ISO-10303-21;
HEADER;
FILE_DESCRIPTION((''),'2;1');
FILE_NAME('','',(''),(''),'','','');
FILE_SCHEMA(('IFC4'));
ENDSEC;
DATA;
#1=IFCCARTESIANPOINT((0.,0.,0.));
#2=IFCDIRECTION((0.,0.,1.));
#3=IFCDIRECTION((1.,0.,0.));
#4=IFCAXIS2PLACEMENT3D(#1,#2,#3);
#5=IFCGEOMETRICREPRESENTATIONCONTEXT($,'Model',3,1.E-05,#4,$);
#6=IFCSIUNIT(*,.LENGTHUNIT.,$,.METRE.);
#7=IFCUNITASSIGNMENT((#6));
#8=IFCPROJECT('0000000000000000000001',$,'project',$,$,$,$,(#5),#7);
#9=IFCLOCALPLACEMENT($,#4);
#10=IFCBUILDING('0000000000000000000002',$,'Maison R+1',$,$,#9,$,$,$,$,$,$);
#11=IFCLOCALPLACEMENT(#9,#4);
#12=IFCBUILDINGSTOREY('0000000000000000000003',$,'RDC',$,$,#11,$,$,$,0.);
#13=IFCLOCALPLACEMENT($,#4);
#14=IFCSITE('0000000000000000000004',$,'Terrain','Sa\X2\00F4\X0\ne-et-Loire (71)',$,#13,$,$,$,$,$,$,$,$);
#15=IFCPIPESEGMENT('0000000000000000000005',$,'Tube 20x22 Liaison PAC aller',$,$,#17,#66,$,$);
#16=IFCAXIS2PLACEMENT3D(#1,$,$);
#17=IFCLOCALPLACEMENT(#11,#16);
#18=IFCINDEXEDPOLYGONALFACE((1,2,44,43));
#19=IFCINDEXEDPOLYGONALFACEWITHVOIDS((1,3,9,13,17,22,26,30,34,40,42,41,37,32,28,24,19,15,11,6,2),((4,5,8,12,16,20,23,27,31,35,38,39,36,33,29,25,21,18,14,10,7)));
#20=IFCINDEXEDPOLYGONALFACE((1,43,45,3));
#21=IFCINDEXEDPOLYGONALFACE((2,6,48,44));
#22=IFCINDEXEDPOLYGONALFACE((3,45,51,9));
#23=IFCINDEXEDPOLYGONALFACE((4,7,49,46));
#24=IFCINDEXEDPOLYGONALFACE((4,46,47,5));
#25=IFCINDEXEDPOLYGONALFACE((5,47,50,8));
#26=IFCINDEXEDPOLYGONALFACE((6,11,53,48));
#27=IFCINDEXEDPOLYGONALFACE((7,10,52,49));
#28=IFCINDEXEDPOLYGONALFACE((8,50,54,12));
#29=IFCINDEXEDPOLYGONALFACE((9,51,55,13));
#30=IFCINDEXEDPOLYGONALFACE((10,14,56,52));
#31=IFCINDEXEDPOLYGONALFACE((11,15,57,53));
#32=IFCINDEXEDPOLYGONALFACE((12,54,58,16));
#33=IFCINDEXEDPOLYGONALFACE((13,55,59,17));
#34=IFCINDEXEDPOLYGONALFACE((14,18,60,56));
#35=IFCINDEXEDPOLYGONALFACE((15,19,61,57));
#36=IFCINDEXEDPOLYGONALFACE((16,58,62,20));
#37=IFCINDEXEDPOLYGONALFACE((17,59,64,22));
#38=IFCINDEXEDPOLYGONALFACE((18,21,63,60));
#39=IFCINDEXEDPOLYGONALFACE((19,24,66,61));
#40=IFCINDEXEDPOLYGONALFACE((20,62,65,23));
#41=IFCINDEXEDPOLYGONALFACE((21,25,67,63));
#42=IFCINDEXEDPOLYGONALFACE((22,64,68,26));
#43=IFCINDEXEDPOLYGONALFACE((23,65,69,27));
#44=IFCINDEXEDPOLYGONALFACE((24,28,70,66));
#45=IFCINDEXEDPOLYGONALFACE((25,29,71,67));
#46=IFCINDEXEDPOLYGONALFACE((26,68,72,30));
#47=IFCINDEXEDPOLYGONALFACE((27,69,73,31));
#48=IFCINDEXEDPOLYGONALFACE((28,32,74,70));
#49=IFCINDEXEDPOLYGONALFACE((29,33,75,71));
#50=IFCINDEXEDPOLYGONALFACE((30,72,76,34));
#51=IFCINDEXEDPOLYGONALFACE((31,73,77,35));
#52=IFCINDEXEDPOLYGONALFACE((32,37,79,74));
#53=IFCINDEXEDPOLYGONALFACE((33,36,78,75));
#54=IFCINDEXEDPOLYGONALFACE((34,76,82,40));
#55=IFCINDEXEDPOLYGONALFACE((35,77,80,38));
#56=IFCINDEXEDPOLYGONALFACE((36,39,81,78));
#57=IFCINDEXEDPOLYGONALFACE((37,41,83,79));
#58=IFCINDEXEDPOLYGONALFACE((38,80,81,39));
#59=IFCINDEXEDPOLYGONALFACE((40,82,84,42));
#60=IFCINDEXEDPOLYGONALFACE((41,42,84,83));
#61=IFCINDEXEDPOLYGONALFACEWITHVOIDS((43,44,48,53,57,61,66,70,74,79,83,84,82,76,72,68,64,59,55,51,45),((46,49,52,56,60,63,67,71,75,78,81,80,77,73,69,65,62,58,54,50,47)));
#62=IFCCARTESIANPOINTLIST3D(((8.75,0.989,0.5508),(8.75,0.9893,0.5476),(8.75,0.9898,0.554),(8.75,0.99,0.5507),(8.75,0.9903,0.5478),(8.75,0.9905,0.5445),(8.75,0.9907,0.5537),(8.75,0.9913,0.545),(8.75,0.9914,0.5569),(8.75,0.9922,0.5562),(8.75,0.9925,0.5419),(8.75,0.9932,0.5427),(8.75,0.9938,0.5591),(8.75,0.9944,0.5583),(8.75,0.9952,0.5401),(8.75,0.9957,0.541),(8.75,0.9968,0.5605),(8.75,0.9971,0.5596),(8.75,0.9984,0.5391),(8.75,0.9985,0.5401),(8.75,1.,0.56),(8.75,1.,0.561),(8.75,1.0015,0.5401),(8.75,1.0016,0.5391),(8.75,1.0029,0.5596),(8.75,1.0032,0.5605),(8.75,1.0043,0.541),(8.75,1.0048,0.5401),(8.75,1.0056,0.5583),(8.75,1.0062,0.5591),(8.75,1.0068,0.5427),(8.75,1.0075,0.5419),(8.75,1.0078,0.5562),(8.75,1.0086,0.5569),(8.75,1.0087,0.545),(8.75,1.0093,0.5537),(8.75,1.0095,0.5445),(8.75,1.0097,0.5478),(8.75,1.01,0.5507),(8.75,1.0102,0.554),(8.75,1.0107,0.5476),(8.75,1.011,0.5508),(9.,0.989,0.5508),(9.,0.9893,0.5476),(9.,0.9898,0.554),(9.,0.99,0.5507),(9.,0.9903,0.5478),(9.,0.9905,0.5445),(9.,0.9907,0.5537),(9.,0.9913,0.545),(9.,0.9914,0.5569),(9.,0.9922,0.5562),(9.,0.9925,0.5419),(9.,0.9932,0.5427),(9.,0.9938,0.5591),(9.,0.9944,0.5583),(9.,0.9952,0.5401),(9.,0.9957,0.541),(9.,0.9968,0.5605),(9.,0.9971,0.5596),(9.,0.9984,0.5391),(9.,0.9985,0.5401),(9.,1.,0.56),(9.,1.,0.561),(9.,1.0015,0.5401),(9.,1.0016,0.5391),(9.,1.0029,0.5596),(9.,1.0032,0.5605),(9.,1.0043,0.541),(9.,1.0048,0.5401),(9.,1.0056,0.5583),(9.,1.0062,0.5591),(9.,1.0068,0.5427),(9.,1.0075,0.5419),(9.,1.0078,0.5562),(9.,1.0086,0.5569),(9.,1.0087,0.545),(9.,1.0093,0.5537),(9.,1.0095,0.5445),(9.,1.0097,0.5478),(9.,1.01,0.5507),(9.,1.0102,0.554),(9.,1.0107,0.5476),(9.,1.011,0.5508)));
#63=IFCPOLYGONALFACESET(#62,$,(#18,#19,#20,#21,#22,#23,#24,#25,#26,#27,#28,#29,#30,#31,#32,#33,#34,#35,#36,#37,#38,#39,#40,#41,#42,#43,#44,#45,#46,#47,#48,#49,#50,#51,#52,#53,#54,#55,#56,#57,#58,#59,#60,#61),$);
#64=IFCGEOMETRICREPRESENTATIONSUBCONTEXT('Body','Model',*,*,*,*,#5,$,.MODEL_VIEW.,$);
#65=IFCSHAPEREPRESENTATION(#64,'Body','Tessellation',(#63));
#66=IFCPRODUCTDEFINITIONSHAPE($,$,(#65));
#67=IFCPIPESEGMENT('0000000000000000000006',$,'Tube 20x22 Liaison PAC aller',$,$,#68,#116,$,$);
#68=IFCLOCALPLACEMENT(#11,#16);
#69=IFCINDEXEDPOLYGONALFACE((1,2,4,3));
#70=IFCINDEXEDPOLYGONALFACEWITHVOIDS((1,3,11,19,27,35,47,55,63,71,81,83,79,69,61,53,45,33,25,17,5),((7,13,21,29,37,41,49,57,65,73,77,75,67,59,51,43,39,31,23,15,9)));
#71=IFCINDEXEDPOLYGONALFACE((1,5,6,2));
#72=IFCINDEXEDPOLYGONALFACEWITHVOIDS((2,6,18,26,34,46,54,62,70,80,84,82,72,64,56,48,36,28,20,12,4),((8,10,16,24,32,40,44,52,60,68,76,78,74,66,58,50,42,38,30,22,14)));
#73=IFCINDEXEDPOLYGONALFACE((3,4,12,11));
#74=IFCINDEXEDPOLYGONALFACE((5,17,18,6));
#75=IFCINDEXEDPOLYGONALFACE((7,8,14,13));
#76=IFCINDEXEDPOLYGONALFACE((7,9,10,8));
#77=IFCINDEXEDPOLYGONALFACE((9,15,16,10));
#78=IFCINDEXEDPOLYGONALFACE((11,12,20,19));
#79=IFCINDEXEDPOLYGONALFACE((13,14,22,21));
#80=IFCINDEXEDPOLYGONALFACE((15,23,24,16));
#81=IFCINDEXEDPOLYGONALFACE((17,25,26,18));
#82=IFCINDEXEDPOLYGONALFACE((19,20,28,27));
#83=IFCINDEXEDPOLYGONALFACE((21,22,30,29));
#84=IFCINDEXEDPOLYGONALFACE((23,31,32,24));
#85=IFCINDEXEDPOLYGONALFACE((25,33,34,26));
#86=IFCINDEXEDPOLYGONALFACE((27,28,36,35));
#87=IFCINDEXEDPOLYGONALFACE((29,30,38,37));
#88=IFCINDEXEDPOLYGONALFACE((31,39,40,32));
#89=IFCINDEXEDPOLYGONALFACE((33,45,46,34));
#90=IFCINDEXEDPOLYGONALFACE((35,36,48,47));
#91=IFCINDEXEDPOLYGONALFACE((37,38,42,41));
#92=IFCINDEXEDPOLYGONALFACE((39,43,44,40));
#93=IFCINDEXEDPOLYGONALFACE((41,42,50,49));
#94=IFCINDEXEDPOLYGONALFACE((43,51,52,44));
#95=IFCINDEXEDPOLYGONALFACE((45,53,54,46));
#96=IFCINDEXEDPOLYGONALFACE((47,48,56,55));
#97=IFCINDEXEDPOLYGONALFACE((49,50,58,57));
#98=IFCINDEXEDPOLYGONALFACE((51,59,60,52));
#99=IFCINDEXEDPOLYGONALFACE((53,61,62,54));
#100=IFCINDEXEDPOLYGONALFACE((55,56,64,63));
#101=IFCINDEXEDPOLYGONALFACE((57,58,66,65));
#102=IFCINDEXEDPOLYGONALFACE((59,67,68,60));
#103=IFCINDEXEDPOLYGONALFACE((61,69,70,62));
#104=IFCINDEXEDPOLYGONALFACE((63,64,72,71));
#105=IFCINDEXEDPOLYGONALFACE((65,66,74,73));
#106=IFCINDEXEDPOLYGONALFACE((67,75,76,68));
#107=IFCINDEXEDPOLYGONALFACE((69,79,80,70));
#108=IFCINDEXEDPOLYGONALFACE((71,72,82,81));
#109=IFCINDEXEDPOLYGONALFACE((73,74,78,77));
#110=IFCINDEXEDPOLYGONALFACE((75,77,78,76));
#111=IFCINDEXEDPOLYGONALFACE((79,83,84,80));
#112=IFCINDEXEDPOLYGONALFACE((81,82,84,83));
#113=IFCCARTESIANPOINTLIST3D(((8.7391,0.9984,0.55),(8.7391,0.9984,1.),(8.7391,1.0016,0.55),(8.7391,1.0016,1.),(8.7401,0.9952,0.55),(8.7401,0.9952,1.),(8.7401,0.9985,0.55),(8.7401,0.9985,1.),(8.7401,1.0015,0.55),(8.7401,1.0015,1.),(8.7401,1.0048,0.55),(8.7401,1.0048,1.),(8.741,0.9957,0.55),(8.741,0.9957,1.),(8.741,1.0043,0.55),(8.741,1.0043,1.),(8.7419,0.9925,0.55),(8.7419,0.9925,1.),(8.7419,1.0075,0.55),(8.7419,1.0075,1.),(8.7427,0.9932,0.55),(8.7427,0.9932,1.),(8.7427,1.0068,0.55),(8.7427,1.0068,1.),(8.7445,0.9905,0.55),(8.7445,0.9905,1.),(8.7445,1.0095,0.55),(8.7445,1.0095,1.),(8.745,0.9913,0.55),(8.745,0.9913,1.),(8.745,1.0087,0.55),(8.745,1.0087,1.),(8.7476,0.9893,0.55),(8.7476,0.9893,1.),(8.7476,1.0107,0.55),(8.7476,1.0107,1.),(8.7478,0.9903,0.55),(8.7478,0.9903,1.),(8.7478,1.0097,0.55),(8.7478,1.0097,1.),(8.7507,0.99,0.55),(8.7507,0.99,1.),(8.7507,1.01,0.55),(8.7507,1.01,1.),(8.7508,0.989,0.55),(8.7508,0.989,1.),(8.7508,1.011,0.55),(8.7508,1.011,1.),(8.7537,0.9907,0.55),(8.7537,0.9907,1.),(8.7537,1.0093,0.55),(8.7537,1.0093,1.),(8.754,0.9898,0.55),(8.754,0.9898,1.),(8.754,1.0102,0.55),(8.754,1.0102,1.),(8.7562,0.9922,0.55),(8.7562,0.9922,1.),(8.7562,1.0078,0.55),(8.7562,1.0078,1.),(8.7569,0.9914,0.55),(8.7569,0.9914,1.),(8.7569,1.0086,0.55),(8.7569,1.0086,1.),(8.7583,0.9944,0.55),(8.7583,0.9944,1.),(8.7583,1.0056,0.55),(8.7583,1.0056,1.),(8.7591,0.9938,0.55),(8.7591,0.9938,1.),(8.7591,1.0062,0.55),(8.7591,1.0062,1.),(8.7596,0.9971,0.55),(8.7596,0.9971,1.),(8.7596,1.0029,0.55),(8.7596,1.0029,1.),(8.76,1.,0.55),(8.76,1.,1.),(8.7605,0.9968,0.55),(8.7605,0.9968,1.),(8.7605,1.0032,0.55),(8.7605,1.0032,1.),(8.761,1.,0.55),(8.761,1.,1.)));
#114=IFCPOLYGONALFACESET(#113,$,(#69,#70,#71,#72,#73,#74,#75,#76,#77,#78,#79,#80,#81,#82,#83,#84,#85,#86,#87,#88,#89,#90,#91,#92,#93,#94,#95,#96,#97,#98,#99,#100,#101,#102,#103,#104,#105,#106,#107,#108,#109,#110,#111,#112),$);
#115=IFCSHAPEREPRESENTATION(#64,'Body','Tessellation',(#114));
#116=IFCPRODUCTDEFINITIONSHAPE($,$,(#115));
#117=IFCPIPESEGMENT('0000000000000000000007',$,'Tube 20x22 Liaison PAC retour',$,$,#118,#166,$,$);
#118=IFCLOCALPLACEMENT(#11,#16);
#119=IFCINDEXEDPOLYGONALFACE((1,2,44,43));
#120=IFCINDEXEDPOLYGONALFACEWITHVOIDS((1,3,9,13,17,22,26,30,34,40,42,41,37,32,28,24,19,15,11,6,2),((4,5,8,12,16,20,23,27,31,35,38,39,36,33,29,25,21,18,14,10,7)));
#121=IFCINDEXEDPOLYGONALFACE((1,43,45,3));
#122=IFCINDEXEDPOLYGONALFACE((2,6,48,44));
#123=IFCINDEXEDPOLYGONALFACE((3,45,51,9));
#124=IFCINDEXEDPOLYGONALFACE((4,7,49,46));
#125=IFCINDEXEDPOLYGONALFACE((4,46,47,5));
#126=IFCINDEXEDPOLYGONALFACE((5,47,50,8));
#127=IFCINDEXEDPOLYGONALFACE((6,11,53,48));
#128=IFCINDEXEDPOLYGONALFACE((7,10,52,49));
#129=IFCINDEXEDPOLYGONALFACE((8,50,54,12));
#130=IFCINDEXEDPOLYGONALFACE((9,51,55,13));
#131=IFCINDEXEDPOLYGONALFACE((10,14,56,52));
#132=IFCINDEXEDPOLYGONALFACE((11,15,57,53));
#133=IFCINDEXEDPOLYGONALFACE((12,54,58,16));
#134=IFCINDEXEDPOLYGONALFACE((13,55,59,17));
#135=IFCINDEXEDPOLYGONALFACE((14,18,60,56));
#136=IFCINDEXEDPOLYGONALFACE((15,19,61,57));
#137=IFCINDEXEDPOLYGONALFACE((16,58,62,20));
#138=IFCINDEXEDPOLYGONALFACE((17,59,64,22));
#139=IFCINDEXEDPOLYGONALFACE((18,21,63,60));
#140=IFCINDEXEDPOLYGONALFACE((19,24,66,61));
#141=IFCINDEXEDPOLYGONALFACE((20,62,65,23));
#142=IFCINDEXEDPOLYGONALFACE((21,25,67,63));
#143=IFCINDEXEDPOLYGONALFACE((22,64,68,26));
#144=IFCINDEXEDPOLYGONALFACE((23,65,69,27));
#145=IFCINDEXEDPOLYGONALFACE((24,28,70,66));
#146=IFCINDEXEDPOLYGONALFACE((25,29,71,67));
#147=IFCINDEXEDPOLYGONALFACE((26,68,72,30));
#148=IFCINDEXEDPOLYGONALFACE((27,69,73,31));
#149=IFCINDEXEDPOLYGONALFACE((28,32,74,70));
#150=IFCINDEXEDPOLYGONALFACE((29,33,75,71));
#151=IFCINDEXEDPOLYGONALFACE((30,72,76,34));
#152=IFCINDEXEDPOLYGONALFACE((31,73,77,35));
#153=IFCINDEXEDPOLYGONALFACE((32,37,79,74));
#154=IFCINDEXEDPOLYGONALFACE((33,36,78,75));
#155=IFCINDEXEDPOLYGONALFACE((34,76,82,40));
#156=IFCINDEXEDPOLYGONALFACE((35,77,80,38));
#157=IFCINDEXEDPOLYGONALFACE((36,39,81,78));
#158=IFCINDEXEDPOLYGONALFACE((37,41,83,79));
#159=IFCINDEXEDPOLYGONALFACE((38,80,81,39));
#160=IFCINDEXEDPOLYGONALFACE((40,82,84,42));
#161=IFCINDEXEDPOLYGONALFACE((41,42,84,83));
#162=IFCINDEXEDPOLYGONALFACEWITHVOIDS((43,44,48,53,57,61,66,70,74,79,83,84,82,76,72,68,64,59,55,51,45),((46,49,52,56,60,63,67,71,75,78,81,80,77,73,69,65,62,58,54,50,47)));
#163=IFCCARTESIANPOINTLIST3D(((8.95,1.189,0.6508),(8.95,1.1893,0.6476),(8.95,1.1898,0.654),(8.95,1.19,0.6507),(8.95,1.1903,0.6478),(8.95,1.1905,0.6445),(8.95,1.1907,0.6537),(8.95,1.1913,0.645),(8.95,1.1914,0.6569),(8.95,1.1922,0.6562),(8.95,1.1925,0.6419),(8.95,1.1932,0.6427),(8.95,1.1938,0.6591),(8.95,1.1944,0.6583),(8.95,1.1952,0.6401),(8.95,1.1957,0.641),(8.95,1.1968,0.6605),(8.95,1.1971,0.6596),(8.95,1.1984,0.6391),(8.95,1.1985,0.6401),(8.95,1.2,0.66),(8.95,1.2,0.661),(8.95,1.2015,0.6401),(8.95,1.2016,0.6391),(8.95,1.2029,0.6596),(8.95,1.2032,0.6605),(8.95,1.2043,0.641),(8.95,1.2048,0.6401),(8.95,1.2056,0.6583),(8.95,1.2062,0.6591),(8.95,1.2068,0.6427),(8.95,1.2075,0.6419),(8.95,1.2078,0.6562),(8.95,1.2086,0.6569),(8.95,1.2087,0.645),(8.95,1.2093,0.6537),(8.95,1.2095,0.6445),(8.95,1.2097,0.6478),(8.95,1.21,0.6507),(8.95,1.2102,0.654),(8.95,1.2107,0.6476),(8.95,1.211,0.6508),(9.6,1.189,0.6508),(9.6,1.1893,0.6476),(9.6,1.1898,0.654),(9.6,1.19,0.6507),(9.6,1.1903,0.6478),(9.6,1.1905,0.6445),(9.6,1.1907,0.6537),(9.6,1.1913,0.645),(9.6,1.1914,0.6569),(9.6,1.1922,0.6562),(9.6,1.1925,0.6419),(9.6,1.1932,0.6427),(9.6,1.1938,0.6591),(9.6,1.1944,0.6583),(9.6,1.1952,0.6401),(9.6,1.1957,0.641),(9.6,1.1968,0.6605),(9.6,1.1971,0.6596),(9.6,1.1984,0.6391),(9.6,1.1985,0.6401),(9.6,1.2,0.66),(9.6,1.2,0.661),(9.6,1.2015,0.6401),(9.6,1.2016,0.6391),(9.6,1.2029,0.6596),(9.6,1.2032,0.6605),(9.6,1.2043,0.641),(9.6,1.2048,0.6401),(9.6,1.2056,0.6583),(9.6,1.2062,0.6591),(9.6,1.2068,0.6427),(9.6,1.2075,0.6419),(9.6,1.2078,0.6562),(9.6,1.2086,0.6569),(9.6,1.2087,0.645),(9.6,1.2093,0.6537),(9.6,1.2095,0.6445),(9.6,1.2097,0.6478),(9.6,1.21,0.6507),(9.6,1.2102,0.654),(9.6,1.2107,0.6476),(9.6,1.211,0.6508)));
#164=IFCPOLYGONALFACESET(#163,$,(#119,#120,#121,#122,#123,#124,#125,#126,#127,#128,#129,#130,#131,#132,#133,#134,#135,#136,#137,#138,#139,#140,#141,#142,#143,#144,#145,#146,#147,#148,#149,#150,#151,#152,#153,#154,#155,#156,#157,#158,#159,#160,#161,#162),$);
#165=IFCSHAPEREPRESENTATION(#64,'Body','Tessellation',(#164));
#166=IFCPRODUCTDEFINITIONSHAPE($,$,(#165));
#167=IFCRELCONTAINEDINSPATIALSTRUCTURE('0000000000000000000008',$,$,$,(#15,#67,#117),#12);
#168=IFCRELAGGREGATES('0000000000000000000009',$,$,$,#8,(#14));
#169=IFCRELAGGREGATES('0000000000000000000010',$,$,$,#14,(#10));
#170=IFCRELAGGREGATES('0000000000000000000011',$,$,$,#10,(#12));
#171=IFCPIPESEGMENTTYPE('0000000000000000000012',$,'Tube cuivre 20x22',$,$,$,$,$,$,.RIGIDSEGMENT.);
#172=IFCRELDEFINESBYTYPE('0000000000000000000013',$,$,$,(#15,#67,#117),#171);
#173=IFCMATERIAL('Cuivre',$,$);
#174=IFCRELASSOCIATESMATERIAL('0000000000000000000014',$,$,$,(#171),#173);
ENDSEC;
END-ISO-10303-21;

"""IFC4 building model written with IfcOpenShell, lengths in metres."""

from ifc_helpers import new_model, si_unit, frame, origin_with_axes, place, context, subcontext, project, spatial, hollow_circle, extrude, material, type_object, element, save


model = new_model("IFC4")

# Units and contexts
model_context = context("Model", 3, precision=1e-05, world=origin_with_axes())
body_context = subcontext(model_context, "Body", "Model", "MODEL_VIEW")
ifc_project = project(units=[si_unit("LENGTHUNIT", "METRE")], contexts=[model_context])

# Site, building, storey
site_placement = place(None, origin_with_axes())
site = spatial("IfcSite", under=ifc_project, at=site_placement, Name="Terrain", Description="Saône-et-Loire (71)")
building_placement = place(None, origin_with_axes())
building = spatial("IfcBuilding", under=site, at=building_placement, Name="Maison R+1")
storey_placement = place(building_placement, origin_with_axes())
storey = spatial("IfcBuildingStorey", under=building, at=storey_placement, Name="RDC", Elevation=0.0)

# Pipe segments
ifc_material_1 = material(Name="Cuivre")
pipe_segment_type_1 = type_object("IfcPipeSegmentType", Name="Tube cuivre 20x22", PredefinedType="RIGIDSEGMENT", material=ifc_material_1)
pipe_segment_1_placement = place(storey_placement, frame((9.0, 1.0, 0.55), z_axis=(-1.0, 0.0, 0.0), x_axis=(0.0, 0.0, 1.0)))
element("IfcPipeSegment", 1, at=pipe_segment_1_placement, inside=storey, type_object=pipe_segment_type_1, Name="Tube 20x22 Liaison PAC aller", context=body_context, shape_type="SweptSolid", body=[
    extrude(hollow_circle(Radius=0.011, WallThickness=0.001), origin_with_axes(), (0.0, 0.0, 1.0), 0.25),
])
pipe_segment_2_placement = place(storey_placement, frame((8.75, 1.0, 0.55), z_axis=(0.0, 0.0, 1.0), x_axis=(1.0, 0.0, 0.0)))
element("IfcPipeSegment", 2, at=pipe_segment_2_placement, inside=storey, type_object=pipe_segment_type_1, Name="Tube 20x22 Liaison PAC aller", context=body_context, shape_type="SweptSolid", body=[
    extrude(hollow_circle(Radius=0.011, WallThickness=0.001), origin_with_axes(), (0.0, 0.0, 1.0), 0.45),
])
pipe_segment_3_placement = place(storey_placement, frame((9.6, 1.2, 0.65), z_axis=(-1.0, 0.0, 0.0), x_axis=(0.0, 0.0, 1.0)))
element("IfcPipeSegment", 3, at=pipe_segment_3_placement, inside=storey, type_object=pipe_segment_type_1, Name="Tube 20x22 Liaison PAC retour", context=body_context, shape_type="SweptSolid", body=[
    extrude(hollow_circle(Radius=0.011, WallThickness=0.001), origin_with_axes(), (0.0, 0.0, 1.0), 0.65),
])

save(model, "model.ifc")
